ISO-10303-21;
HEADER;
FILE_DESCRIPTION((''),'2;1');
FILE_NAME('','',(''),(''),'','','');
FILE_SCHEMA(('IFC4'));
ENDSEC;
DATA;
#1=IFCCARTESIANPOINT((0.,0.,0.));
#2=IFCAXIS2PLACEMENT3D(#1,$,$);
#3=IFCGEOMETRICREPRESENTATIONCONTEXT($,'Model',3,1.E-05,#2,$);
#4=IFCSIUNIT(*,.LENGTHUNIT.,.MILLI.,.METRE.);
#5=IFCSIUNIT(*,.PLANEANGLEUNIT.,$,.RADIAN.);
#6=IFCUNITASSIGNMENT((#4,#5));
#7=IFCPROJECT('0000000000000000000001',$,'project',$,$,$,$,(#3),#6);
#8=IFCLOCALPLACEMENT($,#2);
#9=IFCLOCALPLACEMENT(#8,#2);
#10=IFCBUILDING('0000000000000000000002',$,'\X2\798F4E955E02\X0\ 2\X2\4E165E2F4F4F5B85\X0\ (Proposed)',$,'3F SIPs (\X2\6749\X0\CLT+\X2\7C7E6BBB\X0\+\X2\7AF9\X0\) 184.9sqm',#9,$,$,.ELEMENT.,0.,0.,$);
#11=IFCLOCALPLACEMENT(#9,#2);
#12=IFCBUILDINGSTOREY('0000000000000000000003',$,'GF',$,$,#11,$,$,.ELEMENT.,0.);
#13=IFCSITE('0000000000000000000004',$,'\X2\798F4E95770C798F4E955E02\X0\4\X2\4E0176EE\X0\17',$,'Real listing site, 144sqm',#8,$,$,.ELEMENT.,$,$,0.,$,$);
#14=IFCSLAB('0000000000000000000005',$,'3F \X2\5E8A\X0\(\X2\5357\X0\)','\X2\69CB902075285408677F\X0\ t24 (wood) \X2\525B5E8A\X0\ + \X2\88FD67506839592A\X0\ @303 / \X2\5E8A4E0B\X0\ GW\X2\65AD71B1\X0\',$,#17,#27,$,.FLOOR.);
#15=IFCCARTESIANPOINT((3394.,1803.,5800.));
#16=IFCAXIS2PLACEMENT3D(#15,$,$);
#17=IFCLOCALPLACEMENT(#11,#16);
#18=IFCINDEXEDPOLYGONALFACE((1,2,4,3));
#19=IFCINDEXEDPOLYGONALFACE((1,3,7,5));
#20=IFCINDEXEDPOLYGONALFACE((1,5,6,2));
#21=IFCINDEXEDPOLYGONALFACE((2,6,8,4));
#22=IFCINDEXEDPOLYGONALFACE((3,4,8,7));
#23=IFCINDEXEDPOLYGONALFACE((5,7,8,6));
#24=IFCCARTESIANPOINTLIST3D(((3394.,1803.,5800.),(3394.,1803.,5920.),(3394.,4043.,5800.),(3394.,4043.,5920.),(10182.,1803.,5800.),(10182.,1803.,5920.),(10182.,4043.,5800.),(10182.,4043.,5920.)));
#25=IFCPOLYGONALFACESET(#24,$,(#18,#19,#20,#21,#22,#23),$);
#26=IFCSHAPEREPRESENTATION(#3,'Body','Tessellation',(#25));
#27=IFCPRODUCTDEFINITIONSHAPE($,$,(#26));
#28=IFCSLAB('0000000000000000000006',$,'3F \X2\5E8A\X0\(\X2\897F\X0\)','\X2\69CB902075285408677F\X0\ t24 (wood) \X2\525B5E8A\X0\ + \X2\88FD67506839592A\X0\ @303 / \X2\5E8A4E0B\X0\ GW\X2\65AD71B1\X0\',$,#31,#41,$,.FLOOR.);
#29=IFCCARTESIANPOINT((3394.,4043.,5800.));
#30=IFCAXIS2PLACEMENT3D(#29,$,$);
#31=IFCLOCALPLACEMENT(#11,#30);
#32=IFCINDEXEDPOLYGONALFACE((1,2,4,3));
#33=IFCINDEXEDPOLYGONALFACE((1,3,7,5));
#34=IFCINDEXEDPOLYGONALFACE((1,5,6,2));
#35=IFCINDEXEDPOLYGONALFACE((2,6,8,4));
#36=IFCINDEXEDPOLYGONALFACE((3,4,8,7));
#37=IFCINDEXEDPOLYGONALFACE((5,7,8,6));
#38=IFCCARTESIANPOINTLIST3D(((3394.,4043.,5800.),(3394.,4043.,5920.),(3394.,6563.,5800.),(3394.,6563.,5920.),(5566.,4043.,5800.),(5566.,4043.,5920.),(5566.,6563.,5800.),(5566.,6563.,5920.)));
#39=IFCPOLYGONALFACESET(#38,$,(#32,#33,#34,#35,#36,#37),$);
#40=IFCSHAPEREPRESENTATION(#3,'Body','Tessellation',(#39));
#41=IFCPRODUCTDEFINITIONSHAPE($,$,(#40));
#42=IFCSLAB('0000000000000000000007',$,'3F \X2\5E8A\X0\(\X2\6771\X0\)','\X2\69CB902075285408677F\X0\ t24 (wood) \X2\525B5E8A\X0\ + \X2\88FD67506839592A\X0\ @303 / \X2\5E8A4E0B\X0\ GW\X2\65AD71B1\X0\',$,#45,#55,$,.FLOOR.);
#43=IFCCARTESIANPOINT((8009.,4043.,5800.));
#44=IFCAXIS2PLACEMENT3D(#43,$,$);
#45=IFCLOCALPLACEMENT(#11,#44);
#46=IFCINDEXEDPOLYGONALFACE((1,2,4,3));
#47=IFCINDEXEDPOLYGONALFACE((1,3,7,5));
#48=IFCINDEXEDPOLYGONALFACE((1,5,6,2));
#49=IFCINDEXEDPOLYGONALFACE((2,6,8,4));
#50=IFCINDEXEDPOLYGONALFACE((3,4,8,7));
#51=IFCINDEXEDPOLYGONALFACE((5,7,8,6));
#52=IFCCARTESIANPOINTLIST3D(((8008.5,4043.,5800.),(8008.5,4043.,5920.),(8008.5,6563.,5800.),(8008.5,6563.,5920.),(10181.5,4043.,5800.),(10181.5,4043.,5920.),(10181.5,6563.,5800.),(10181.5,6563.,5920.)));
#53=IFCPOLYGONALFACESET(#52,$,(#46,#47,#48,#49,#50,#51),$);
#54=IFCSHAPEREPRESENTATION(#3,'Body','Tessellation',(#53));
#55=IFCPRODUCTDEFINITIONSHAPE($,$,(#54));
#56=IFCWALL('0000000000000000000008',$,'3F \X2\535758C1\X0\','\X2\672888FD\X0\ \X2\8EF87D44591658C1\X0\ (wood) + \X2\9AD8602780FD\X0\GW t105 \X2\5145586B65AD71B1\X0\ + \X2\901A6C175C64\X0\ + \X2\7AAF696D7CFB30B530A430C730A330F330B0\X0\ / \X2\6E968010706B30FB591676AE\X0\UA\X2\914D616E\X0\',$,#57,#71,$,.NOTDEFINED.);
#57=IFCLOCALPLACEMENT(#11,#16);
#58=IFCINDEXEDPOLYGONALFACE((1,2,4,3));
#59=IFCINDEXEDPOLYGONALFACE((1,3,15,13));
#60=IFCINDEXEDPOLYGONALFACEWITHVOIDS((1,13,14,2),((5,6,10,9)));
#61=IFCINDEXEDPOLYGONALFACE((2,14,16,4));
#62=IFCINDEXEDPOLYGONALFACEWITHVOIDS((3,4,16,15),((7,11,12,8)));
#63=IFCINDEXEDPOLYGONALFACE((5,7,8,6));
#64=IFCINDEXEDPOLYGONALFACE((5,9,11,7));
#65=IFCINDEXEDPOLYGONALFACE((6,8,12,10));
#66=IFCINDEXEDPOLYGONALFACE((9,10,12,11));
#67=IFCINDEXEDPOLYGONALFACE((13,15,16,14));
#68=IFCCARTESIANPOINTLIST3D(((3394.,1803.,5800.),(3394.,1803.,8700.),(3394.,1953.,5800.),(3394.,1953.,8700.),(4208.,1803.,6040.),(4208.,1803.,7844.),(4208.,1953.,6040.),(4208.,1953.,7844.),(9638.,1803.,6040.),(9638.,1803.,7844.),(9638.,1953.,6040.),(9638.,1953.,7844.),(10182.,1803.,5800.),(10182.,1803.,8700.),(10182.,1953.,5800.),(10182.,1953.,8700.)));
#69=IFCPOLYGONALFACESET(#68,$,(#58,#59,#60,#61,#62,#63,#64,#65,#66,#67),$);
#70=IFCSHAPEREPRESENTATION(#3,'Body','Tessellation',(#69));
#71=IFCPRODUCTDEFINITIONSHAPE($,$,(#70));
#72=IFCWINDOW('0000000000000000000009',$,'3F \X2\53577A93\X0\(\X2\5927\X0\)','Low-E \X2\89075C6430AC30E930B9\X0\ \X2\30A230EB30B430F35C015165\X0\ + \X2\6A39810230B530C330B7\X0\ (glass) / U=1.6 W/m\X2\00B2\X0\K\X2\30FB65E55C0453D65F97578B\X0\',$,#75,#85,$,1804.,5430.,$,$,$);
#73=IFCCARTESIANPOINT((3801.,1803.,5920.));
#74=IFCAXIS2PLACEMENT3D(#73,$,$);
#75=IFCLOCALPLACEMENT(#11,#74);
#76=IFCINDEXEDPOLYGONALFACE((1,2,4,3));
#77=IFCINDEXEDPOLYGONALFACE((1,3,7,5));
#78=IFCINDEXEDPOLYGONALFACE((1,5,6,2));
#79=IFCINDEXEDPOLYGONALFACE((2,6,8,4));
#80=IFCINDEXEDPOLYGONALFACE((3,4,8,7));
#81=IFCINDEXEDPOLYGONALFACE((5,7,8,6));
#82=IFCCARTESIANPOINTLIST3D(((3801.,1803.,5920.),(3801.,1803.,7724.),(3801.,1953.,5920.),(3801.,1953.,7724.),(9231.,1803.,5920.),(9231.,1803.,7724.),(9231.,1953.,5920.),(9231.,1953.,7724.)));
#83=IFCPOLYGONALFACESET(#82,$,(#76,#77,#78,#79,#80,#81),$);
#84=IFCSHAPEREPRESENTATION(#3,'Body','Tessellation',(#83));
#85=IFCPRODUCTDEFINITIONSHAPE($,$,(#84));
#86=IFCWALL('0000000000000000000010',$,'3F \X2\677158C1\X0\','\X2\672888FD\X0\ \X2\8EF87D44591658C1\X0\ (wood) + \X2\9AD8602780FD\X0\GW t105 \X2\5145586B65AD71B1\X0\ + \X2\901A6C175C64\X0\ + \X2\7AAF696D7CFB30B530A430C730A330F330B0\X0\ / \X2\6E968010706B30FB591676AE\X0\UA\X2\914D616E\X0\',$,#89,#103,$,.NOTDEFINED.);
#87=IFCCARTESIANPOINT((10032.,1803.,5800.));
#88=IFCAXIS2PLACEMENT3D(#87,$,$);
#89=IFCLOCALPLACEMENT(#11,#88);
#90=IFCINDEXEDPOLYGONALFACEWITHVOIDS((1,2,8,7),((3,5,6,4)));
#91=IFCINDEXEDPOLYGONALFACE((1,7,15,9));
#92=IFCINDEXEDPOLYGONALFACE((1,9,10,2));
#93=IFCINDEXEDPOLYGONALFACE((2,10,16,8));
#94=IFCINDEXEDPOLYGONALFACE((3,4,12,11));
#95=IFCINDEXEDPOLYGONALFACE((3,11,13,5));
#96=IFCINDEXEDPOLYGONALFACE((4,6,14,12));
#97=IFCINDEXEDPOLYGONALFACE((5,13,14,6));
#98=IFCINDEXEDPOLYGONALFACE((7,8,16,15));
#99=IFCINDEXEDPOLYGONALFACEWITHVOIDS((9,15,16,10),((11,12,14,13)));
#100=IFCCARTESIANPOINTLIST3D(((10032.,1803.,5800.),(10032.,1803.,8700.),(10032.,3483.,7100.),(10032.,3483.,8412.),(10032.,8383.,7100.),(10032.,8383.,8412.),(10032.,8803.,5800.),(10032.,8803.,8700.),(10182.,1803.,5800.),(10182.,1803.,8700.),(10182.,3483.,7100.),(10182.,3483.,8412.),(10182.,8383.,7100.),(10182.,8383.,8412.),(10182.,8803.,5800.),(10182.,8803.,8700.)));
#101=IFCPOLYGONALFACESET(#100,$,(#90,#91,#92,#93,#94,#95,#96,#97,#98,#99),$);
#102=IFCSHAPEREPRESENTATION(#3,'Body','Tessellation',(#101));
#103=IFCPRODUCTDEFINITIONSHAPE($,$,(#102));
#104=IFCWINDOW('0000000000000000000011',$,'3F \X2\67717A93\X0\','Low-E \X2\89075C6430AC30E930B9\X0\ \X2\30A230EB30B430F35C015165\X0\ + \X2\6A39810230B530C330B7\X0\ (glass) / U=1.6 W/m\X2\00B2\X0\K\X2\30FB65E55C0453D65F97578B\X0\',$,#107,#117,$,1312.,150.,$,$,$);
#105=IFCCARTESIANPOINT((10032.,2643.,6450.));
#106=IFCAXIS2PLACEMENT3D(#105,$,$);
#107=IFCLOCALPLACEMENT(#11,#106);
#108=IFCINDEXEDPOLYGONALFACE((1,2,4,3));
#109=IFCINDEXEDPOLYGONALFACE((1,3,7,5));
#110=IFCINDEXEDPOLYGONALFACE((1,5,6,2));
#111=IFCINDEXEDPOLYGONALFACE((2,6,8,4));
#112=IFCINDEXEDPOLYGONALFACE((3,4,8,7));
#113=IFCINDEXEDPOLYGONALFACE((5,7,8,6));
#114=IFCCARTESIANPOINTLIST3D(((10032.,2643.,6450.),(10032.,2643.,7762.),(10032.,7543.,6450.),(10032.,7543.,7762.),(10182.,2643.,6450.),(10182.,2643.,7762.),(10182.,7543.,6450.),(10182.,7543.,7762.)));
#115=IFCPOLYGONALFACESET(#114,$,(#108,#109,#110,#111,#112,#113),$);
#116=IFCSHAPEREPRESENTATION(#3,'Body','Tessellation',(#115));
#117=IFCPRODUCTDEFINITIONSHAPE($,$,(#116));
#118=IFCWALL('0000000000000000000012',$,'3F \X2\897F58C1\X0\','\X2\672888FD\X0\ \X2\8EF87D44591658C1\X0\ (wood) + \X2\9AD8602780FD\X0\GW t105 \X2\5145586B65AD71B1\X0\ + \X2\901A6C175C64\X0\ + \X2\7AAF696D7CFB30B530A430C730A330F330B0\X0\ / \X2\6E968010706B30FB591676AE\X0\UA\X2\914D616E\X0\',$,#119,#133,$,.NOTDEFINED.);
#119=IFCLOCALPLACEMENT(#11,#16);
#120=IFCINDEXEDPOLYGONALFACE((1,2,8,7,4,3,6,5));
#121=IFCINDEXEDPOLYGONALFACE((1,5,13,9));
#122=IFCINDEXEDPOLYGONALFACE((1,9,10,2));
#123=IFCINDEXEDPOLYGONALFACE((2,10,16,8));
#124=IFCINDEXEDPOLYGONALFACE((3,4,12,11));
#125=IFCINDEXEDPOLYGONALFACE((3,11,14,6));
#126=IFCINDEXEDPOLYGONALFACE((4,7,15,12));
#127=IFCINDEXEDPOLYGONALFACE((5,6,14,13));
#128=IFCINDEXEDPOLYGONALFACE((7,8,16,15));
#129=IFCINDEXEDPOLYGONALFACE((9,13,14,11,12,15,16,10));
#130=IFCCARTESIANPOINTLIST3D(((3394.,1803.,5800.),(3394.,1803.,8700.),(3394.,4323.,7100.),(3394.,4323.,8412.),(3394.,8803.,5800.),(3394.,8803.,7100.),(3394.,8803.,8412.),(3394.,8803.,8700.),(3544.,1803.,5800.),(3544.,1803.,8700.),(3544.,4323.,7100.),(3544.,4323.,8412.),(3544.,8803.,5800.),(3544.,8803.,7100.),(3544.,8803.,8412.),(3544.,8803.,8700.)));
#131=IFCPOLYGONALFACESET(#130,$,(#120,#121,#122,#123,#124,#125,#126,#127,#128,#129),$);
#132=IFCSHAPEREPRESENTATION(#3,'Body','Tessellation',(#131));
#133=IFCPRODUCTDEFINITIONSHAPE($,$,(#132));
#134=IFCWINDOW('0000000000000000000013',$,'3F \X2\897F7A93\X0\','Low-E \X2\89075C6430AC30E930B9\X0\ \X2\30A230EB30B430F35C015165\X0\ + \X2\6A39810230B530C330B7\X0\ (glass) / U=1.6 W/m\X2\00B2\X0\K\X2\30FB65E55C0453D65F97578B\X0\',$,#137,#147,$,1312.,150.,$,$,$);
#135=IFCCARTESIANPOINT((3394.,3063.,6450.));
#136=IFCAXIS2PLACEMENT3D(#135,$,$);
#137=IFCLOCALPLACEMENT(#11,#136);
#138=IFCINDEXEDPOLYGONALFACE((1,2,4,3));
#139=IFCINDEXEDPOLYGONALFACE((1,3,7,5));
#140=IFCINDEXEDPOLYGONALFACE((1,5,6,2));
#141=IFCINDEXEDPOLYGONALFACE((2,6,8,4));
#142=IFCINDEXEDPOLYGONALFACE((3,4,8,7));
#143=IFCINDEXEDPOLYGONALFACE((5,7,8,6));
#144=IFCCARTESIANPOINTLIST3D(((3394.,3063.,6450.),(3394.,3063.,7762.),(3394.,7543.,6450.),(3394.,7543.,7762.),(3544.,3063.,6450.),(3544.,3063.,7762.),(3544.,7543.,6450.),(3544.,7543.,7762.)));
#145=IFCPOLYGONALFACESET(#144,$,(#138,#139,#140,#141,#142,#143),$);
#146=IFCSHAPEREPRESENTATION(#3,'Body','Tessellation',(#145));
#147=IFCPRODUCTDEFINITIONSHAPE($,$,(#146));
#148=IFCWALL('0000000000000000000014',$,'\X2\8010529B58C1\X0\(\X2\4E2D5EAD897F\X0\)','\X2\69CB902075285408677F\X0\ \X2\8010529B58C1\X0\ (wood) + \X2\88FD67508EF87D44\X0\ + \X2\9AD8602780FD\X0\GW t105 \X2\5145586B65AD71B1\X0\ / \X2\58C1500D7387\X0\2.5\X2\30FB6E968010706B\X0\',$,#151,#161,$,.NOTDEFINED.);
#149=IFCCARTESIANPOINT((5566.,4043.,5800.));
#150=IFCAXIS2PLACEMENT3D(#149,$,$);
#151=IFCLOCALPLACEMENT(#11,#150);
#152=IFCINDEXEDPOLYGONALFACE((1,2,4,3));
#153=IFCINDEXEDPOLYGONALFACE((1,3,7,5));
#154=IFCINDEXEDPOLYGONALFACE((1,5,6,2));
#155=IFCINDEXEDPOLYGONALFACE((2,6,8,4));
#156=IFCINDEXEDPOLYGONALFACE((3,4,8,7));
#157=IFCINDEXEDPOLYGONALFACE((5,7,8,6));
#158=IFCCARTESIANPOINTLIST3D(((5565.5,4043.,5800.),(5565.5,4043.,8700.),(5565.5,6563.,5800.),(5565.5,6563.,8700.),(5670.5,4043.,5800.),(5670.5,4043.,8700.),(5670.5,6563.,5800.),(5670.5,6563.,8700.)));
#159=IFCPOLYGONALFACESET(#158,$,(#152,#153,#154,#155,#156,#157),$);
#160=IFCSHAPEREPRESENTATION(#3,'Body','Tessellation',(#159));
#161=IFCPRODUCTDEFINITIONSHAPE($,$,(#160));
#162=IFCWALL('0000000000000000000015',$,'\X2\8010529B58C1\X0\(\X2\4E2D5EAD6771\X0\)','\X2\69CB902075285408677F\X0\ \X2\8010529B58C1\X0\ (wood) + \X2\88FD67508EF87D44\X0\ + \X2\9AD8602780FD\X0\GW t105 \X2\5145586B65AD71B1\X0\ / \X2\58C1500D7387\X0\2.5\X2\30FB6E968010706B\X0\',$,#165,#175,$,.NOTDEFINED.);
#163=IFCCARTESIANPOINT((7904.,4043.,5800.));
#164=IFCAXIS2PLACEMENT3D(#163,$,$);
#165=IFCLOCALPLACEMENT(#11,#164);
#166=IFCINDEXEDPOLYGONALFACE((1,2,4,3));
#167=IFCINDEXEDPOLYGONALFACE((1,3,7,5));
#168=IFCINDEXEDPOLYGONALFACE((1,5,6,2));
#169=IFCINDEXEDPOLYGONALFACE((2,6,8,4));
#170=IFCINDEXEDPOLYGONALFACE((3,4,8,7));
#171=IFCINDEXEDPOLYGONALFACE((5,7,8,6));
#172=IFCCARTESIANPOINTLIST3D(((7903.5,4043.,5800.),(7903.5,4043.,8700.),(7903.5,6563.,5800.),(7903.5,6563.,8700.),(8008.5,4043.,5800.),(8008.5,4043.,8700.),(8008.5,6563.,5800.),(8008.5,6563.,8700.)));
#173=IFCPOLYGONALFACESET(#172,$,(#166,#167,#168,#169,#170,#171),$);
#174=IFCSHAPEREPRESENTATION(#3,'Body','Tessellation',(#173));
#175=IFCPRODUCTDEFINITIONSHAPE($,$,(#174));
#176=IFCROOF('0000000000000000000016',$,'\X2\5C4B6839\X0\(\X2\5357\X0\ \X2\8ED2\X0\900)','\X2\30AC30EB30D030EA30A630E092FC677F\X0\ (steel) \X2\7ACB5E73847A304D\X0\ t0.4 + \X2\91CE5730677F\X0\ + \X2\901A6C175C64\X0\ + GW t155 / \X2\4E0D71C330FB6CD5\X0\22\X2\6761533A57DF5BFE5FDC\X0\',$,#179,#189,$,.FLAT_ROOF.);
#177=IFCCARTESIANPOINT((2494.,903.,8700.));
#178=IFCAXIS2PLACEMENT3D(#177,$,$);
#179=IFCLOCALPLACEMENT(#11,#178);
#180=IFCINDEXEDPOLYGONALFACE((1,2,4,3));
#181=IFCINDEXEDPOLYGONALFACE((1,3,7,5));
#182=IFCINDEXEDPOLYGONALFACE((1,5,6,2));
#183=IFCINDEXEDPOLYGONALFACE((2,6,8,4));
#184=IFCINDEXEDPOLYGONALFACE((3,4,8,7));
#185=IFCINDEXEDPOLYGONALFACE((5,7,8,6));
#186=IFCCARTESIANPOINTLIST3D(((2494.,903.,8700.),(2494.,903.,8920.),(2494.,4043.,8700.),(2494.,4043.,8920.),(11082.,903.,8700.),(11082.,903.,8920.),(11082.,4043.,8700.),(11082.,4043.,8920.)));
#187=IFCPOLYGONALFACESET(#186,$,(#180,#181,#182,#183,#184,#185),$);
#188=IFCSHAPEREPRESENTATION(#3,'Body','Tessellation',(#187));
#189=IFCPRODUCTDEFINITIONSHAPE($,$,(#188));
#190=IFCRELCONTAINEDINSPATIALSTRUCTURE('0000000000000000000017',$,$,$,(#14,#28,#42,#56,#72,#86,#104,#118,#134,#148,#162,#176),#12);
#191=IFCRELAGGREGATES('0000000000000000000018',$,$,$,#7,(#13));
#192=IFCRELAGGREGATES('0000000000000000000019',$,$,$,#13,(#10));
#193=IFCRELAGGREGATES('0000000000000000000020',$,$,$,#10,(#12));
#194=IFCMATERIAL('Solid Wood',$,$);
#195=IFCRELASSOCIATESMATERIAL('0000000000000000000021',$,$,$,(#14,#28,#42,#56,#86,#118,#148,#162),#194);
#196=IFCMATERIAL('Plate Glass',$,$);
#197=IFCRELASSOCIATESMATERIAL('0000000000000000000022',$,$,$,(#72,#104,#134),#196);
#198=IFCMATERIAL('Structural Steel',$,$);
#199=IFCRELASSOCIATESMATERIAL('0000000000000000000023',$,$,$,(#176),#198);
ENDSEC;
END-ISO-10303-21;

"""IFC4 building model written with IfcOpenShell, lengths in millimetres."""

from ifc_helpers import new_model, si_unit, frame, frame_2d, origin, place, context, project, spatial, rectangle, extrude, material, element, fill, save


model = new_model("IFC4")

# Units and contexts
model_context = context("Model", 3, precision=1e-05, world=origin())
ifc_project = project(units=[si_unit("LENGTHUNIT", "METRE", prefix="MILLI"), si_unit("PLANEANGLEUNIT", "RADIAN")], contexts=[model_context])

# Site, building, storey
site_placement = place(None, origin())
site = spatial("IfcSite", under=ifc_project, at=site_placement, Name="福井県福井市4丁目17", ObjectType="Real listing site, 144sqm", CompositionType="ELEMENT", RefElevation=0.0)
building_placement = place(site_placement, origin())
building = spatial("IfcBuilding", under=site, at=building_placement, Name="福井市 2世帯住宅 (Proposed)", ObjectType="3F SIPs (杉CLT+籾殻+竹) 184.9sqm", CompositionType="ELEMENT", ElevationOfRefHeight=0.0, ElevationOfTerrain=0.0)
storey_placement = place(building_placement, origin())
storey = spatial("IfcBuildingStorey", under=building, at=storey_placement, Name="GF", CompositionType="ELEMENT", Elevation=0.0)

# Slabs
ifc_material_1 = material(Name="Solid Wood")
slab_1_placement = place(storey_placement, frame((3394.0, 1803.0, 5800.0)))
element("IfcSlab", 1, at=slab_1_placement, inside=storey, material=ifc_material_1, Name="3F 床(南)", Description="構造用合板 t24 (wood) 剛床 + 製材根太 @303 / 床下 GW断熱", PredefinedType="FLOOR", context=model_context, shape_type="SweptSolid", body=[
    extrude(rectangle(XDim=6788.0, YDim=2240.0, at=frame_2d((3394.0, 1120.0))), frame((3394.0, 1803.0, 5800.0)), (0.0, 0.0, 1.0), 120.0),
])
slab_2_placement = place(storey_placement, frame((3394.0, 4043.0, 5800.0)))
element("IfcSlab", 2, at=slab_2_placement, inside=storey, material=ifc_material_1, Name="3F 床(西)", Description="構造用合板 t24 (wood) 剛床 + 製材根太 @303 / 床下 GW断熱", PredefinedType="FLOOR", context=model_context, shape_type="SweptSolid", body=[
    extrude(rectangle(XDim=2172.0, YDim=2520.0, at=frame_2d((1086.0, 1260.0))), frame((3394.0, 4043.0, 5800.0)), (0.0, 0.0, 1.0), 120.0),
])
slab_3_placement = place(storey_placement, frame((8009.0, 4043.0, 5800.0)))
element("IfcSlab", 3, at=slab_3_placement, inside=storey, material=ifc_material_1, Name="3F 床(東)", Description="構造用合板 t24 (wood) 剛床 + 製材根太 @303 / 床下 GW断熱", PredefinedType="FLOOR", context=model_context, shape_type="SweptSolid", body=[
    extrude(rectangle(XDim=2173.0, YDim=2520.0, at=frame_2d((1086.0, 1260.0))), frame((8009.0, 4043.0, 5800.0)), (0.0, 0.0, 1.0), 120.0),
])

# Walls, openings, windows
wall_1_placement = place(storey_placement, frame((3394.0, 1803.0, 5800.0)))
wall_1 = element("IfcWall", 4, at=wall_1_placement, inside=storey, material=ifc_material_1, Name="3F 南壁", Description="木製 軸組外壁 (wood) + 高性能GW t105 充填断熱 + 通気層 + 窯業系サイディング / 準耐火・外皮UA配慮", PredefinedType="NOTDEFINED", context=model_context, shape_type="SweptSolid", body=[
    extrude(rectangle(XDim=6788.0, YDim=150.0, at=frame_2d((3394.0, 75.0))), frame((3394.0, 1803.0, 5800.0)), (0.0, 0.0, 1.0), 2900.0),
])
opening_1_placement = place(storey_placement, frame((3801.0, 1803.0, 5920.0)))
opening_1 = element("IfcOpeningElement", 5, at=opening_1_placement, cuts=wall_1, PredefinedType="NOTDEFINED", context=model_context, shape_type="SweptSolid", body=[
    extrude(rectangle(XDim=5430.0, YDim=150.0, at=frame_2d((2715.0, 75.0))), frame((3801.0, 1803.0, 5920.0)), (0.0, 0.0, 1.0), 1804.0),
])
ifc_material_2 = material(Name="Plate Glass")
window_1_placement = place(storey_placement, frame((3801.0, 1803.0, 5920.0)))
window_1 = element("IfcWindow", 6, at=window_1_placement, inside=storey, material=ifc_material_2, Name="3F 南窓(大)", Description="Low-E 複層ガラス アルゴン封入 + 樹脂サッシ (glass) / U=1.6 W/m²K・日射取得型", OverallHeight=1804.0, OverallWidth=5430.0, context=model_context, shape_type="SweptSolid", body=[
    extrude(rectangle(XDim=5430.0, YDim=150.0, at=frame_2d((2715.0, 75.0))), frame((3801.0, 1803.0, 5920.0)), (0.0, 0.0, 1.0), 1804.0),
])
fill(opening_1, window_1)
wall_2_placement = place(storey_placement, frame((10032.0, 1803.0, 5800.0)))
wall_2 = element("IfcWall", 7, at=wall_2_placement, inside=storey, material=ifc_material_1, Name="3F 東壁", Description="木製 軸組外壁 (wood) + 高性能GW t105 充填断熱 + 通気層 + 窯業系サイディング / 準耐火・外皮UA配慮", PredefinedType="NOTDEFINED", context=model_context, shape_type="SweptSolid", body=[
    extrude(rectangle(XDim=150.0, YDim=7000.0, at=frame_2d((75.0, 3500.0))), frame((10032.0, 1803.0, 5800.0)), (0.0, 0.0, 1.0), 2900.0),
])
opening_2_placement = place(storey_placement, frame((10032.0, 2643.0, 6450.0)))
opening_2 = element("IfcOpeningElement", 8, at=opening_2_placement, cuts=wall_2, PredefinedType="NOTDEFINED", context=model_context, shape_type="SweptSolid", body=[
    extrude(rectangle(XDim=150.0, YDim=4900.0, at=frame_2d((75.0, 2450.0))), frame((10032.0, 2643.0, 6450.0)), (0.0, 0.0, 1.0), 1312.0),
])
window_2_placement = place(storey_placement, frame((10032.0, 2643.0, 6450.0)))
window_2 = element("IfcWindow", 9, at=window_2_placement, inside=storey, material=ifc_material_2, Name="3F 東窓", Description="Low-E 複層ガラス アルゴン封入 + 樹脂サッシ (glass) / U=1.6 W/m²K・日射取得型", OverallHeight=1312.0, OverallWidth=150.0, context=model_context, shape_type="SweptSolid", body=[
    extrude(rectangle(XDim=150.0, YDim=4900.0, at=frame_2d((75.0, 2450.0))), frame((10032.0, 2643.0, 6450.0)), (0.0, 0.0, 1.0), 1312.0),
])
fill(opening_2, window_2)
wall_3_placement = place(storey_placement, frame((3394.0, 1803.0, 5800.0)))
wall_3 = element("IfcWall", 10, at=wall_3_placement, inside=storey, material=ifc_material_1, Name="3F 西壁", Description="木製 軸組外壁 (wood) + 高性能GW t105 充填断熱 + 通気層 + 窯業系サイディング / 準耐火・外皮UA配慮", PredefinedType="NOTDEFINED", context=model_context, shape_type="SweptSolid", body=[
    extrude(rectangle(XDim=150.0, YDim=7000.0, at=frame_2d((75.0, 3500.0))), frame((3394.0, 1803.0, 5800.0)), (0.0, 0.0, 1.0), 2900.0),
])
opening_3_placement = place(storey_placement, frame((3394.0, 3063.0, 6450.0)))
opening_3 = element("IfcOpeningElement", 11, at=opening_3_placement, cuts=wall_3, PredefinedType="NOTDEFINED", context=model_context, shape_type="SweptSolid", body=[
    extrude(rectangle(XDim=150.0, YDim=4480.0, at=frame_2d((75.0, 2240.0))), frame((3394.0, 3063.0, 6450.0)), (0.0, 0.0, 1.0), 1312.0),
])
window_3_placement = place(storey_placement, frame((3394.0, 3063.0, 6450.0)))
window_3 = element("IfcWindow", 12, at=window_3_placement, inside=storey, material=ifc_material_2, Name="3F 西窓", Description="Low-E 複層ガラス アルゴン封入 + 樹脂サッシ (glass) / U=1.6 W/m²K・日射取得型", OverallHeight=1312.0, OverallWidth=150.0, context=model_context, shape_type="SweptSolid", body=[
    extrude(rectangle(XDim=150.0, YDim=4480.0, at=frame_2d((75.0, 2240.0))), frame((3394.0, 3063.0, 6450.0)), (0.0, 0.0, 1.0), 1312.0),
])
fill(opening_3, window_3)

# Walls
wall_4_placement = place(storey_placement, frame((5566.0, 4043.0, 5800.0)))
element("IfcWall", 13, at=wall_4_placement, inside=storey, material=ifc_material_1, Name="耐力壁(中庭西)", Description="構造用合板 耐力壁 (wood) + 製材軸組 + 高性能GW t105 充填断熱 / 壁倍率2.5・準耐火", PredefinedType="NOTDEFINED", context=model_context, shape_type="SweptSolid", body=[
    extrude(rectangle(XDim=105.0, YDim=2520.0, at=frame_2d((52.0, 1260.0))), frame((5566.0, 4043.0, 5800.0)), (0.0, 0.0, 1.0), 2900.0),
])
wall_5_placement = place(storey_placement, frame((7904.0, 4043.0, 5800.0)))
element("IfcWall", 14, at=wall_5_placement, inside=storey, material=ifc_material_1, Name="耐力壁(中庭東)", Description="構造用合板 耐力壁 (wood) + 製材軸組 + 高性能GW t105 充填断熱 / 壁倍率2.5・準耐火", PredefinedType="NOTDEFINED", context=model_context, shape_type="SweptSolid", body=[
    extrude(rectangle(XDim=105.0, YDim=2520.0, at=frame_2d((52.0, 1260.0))), frame((7904.0, 4043.0, 5800.0)), (0.0, 0.0, 1.0), 2900.0),
])

# Roof
ifc_material_3 = material(Name="Structural Steel")
roof_1_placement = place(storey_placement, frame((2494.0, 903.0, 8700.0)))
element("IfcRoof", 15, at=roof_1_placement, inside=storey, material=ifc_material_3, Name="屋根(南 軒900)", Description="ガルバリウム鋼板 (steel) 立平葺き t0.4 + 野地板 + 通気層 + GW t155 / 不燃・法22条区域対応", PredefinedType="FLAT_ROOF", context=model_context, shape_type="SweptSolid", body=[
    extrude(rectangle(XDim=8588.0, YDim=3140.0, at=frame_2d((4294.0, 1570.0))), frame((2494.0, 903.0, 8700.0)), (0.0, 0.0, 1.0), 220.0),
])

save(model, "model.ifc")
